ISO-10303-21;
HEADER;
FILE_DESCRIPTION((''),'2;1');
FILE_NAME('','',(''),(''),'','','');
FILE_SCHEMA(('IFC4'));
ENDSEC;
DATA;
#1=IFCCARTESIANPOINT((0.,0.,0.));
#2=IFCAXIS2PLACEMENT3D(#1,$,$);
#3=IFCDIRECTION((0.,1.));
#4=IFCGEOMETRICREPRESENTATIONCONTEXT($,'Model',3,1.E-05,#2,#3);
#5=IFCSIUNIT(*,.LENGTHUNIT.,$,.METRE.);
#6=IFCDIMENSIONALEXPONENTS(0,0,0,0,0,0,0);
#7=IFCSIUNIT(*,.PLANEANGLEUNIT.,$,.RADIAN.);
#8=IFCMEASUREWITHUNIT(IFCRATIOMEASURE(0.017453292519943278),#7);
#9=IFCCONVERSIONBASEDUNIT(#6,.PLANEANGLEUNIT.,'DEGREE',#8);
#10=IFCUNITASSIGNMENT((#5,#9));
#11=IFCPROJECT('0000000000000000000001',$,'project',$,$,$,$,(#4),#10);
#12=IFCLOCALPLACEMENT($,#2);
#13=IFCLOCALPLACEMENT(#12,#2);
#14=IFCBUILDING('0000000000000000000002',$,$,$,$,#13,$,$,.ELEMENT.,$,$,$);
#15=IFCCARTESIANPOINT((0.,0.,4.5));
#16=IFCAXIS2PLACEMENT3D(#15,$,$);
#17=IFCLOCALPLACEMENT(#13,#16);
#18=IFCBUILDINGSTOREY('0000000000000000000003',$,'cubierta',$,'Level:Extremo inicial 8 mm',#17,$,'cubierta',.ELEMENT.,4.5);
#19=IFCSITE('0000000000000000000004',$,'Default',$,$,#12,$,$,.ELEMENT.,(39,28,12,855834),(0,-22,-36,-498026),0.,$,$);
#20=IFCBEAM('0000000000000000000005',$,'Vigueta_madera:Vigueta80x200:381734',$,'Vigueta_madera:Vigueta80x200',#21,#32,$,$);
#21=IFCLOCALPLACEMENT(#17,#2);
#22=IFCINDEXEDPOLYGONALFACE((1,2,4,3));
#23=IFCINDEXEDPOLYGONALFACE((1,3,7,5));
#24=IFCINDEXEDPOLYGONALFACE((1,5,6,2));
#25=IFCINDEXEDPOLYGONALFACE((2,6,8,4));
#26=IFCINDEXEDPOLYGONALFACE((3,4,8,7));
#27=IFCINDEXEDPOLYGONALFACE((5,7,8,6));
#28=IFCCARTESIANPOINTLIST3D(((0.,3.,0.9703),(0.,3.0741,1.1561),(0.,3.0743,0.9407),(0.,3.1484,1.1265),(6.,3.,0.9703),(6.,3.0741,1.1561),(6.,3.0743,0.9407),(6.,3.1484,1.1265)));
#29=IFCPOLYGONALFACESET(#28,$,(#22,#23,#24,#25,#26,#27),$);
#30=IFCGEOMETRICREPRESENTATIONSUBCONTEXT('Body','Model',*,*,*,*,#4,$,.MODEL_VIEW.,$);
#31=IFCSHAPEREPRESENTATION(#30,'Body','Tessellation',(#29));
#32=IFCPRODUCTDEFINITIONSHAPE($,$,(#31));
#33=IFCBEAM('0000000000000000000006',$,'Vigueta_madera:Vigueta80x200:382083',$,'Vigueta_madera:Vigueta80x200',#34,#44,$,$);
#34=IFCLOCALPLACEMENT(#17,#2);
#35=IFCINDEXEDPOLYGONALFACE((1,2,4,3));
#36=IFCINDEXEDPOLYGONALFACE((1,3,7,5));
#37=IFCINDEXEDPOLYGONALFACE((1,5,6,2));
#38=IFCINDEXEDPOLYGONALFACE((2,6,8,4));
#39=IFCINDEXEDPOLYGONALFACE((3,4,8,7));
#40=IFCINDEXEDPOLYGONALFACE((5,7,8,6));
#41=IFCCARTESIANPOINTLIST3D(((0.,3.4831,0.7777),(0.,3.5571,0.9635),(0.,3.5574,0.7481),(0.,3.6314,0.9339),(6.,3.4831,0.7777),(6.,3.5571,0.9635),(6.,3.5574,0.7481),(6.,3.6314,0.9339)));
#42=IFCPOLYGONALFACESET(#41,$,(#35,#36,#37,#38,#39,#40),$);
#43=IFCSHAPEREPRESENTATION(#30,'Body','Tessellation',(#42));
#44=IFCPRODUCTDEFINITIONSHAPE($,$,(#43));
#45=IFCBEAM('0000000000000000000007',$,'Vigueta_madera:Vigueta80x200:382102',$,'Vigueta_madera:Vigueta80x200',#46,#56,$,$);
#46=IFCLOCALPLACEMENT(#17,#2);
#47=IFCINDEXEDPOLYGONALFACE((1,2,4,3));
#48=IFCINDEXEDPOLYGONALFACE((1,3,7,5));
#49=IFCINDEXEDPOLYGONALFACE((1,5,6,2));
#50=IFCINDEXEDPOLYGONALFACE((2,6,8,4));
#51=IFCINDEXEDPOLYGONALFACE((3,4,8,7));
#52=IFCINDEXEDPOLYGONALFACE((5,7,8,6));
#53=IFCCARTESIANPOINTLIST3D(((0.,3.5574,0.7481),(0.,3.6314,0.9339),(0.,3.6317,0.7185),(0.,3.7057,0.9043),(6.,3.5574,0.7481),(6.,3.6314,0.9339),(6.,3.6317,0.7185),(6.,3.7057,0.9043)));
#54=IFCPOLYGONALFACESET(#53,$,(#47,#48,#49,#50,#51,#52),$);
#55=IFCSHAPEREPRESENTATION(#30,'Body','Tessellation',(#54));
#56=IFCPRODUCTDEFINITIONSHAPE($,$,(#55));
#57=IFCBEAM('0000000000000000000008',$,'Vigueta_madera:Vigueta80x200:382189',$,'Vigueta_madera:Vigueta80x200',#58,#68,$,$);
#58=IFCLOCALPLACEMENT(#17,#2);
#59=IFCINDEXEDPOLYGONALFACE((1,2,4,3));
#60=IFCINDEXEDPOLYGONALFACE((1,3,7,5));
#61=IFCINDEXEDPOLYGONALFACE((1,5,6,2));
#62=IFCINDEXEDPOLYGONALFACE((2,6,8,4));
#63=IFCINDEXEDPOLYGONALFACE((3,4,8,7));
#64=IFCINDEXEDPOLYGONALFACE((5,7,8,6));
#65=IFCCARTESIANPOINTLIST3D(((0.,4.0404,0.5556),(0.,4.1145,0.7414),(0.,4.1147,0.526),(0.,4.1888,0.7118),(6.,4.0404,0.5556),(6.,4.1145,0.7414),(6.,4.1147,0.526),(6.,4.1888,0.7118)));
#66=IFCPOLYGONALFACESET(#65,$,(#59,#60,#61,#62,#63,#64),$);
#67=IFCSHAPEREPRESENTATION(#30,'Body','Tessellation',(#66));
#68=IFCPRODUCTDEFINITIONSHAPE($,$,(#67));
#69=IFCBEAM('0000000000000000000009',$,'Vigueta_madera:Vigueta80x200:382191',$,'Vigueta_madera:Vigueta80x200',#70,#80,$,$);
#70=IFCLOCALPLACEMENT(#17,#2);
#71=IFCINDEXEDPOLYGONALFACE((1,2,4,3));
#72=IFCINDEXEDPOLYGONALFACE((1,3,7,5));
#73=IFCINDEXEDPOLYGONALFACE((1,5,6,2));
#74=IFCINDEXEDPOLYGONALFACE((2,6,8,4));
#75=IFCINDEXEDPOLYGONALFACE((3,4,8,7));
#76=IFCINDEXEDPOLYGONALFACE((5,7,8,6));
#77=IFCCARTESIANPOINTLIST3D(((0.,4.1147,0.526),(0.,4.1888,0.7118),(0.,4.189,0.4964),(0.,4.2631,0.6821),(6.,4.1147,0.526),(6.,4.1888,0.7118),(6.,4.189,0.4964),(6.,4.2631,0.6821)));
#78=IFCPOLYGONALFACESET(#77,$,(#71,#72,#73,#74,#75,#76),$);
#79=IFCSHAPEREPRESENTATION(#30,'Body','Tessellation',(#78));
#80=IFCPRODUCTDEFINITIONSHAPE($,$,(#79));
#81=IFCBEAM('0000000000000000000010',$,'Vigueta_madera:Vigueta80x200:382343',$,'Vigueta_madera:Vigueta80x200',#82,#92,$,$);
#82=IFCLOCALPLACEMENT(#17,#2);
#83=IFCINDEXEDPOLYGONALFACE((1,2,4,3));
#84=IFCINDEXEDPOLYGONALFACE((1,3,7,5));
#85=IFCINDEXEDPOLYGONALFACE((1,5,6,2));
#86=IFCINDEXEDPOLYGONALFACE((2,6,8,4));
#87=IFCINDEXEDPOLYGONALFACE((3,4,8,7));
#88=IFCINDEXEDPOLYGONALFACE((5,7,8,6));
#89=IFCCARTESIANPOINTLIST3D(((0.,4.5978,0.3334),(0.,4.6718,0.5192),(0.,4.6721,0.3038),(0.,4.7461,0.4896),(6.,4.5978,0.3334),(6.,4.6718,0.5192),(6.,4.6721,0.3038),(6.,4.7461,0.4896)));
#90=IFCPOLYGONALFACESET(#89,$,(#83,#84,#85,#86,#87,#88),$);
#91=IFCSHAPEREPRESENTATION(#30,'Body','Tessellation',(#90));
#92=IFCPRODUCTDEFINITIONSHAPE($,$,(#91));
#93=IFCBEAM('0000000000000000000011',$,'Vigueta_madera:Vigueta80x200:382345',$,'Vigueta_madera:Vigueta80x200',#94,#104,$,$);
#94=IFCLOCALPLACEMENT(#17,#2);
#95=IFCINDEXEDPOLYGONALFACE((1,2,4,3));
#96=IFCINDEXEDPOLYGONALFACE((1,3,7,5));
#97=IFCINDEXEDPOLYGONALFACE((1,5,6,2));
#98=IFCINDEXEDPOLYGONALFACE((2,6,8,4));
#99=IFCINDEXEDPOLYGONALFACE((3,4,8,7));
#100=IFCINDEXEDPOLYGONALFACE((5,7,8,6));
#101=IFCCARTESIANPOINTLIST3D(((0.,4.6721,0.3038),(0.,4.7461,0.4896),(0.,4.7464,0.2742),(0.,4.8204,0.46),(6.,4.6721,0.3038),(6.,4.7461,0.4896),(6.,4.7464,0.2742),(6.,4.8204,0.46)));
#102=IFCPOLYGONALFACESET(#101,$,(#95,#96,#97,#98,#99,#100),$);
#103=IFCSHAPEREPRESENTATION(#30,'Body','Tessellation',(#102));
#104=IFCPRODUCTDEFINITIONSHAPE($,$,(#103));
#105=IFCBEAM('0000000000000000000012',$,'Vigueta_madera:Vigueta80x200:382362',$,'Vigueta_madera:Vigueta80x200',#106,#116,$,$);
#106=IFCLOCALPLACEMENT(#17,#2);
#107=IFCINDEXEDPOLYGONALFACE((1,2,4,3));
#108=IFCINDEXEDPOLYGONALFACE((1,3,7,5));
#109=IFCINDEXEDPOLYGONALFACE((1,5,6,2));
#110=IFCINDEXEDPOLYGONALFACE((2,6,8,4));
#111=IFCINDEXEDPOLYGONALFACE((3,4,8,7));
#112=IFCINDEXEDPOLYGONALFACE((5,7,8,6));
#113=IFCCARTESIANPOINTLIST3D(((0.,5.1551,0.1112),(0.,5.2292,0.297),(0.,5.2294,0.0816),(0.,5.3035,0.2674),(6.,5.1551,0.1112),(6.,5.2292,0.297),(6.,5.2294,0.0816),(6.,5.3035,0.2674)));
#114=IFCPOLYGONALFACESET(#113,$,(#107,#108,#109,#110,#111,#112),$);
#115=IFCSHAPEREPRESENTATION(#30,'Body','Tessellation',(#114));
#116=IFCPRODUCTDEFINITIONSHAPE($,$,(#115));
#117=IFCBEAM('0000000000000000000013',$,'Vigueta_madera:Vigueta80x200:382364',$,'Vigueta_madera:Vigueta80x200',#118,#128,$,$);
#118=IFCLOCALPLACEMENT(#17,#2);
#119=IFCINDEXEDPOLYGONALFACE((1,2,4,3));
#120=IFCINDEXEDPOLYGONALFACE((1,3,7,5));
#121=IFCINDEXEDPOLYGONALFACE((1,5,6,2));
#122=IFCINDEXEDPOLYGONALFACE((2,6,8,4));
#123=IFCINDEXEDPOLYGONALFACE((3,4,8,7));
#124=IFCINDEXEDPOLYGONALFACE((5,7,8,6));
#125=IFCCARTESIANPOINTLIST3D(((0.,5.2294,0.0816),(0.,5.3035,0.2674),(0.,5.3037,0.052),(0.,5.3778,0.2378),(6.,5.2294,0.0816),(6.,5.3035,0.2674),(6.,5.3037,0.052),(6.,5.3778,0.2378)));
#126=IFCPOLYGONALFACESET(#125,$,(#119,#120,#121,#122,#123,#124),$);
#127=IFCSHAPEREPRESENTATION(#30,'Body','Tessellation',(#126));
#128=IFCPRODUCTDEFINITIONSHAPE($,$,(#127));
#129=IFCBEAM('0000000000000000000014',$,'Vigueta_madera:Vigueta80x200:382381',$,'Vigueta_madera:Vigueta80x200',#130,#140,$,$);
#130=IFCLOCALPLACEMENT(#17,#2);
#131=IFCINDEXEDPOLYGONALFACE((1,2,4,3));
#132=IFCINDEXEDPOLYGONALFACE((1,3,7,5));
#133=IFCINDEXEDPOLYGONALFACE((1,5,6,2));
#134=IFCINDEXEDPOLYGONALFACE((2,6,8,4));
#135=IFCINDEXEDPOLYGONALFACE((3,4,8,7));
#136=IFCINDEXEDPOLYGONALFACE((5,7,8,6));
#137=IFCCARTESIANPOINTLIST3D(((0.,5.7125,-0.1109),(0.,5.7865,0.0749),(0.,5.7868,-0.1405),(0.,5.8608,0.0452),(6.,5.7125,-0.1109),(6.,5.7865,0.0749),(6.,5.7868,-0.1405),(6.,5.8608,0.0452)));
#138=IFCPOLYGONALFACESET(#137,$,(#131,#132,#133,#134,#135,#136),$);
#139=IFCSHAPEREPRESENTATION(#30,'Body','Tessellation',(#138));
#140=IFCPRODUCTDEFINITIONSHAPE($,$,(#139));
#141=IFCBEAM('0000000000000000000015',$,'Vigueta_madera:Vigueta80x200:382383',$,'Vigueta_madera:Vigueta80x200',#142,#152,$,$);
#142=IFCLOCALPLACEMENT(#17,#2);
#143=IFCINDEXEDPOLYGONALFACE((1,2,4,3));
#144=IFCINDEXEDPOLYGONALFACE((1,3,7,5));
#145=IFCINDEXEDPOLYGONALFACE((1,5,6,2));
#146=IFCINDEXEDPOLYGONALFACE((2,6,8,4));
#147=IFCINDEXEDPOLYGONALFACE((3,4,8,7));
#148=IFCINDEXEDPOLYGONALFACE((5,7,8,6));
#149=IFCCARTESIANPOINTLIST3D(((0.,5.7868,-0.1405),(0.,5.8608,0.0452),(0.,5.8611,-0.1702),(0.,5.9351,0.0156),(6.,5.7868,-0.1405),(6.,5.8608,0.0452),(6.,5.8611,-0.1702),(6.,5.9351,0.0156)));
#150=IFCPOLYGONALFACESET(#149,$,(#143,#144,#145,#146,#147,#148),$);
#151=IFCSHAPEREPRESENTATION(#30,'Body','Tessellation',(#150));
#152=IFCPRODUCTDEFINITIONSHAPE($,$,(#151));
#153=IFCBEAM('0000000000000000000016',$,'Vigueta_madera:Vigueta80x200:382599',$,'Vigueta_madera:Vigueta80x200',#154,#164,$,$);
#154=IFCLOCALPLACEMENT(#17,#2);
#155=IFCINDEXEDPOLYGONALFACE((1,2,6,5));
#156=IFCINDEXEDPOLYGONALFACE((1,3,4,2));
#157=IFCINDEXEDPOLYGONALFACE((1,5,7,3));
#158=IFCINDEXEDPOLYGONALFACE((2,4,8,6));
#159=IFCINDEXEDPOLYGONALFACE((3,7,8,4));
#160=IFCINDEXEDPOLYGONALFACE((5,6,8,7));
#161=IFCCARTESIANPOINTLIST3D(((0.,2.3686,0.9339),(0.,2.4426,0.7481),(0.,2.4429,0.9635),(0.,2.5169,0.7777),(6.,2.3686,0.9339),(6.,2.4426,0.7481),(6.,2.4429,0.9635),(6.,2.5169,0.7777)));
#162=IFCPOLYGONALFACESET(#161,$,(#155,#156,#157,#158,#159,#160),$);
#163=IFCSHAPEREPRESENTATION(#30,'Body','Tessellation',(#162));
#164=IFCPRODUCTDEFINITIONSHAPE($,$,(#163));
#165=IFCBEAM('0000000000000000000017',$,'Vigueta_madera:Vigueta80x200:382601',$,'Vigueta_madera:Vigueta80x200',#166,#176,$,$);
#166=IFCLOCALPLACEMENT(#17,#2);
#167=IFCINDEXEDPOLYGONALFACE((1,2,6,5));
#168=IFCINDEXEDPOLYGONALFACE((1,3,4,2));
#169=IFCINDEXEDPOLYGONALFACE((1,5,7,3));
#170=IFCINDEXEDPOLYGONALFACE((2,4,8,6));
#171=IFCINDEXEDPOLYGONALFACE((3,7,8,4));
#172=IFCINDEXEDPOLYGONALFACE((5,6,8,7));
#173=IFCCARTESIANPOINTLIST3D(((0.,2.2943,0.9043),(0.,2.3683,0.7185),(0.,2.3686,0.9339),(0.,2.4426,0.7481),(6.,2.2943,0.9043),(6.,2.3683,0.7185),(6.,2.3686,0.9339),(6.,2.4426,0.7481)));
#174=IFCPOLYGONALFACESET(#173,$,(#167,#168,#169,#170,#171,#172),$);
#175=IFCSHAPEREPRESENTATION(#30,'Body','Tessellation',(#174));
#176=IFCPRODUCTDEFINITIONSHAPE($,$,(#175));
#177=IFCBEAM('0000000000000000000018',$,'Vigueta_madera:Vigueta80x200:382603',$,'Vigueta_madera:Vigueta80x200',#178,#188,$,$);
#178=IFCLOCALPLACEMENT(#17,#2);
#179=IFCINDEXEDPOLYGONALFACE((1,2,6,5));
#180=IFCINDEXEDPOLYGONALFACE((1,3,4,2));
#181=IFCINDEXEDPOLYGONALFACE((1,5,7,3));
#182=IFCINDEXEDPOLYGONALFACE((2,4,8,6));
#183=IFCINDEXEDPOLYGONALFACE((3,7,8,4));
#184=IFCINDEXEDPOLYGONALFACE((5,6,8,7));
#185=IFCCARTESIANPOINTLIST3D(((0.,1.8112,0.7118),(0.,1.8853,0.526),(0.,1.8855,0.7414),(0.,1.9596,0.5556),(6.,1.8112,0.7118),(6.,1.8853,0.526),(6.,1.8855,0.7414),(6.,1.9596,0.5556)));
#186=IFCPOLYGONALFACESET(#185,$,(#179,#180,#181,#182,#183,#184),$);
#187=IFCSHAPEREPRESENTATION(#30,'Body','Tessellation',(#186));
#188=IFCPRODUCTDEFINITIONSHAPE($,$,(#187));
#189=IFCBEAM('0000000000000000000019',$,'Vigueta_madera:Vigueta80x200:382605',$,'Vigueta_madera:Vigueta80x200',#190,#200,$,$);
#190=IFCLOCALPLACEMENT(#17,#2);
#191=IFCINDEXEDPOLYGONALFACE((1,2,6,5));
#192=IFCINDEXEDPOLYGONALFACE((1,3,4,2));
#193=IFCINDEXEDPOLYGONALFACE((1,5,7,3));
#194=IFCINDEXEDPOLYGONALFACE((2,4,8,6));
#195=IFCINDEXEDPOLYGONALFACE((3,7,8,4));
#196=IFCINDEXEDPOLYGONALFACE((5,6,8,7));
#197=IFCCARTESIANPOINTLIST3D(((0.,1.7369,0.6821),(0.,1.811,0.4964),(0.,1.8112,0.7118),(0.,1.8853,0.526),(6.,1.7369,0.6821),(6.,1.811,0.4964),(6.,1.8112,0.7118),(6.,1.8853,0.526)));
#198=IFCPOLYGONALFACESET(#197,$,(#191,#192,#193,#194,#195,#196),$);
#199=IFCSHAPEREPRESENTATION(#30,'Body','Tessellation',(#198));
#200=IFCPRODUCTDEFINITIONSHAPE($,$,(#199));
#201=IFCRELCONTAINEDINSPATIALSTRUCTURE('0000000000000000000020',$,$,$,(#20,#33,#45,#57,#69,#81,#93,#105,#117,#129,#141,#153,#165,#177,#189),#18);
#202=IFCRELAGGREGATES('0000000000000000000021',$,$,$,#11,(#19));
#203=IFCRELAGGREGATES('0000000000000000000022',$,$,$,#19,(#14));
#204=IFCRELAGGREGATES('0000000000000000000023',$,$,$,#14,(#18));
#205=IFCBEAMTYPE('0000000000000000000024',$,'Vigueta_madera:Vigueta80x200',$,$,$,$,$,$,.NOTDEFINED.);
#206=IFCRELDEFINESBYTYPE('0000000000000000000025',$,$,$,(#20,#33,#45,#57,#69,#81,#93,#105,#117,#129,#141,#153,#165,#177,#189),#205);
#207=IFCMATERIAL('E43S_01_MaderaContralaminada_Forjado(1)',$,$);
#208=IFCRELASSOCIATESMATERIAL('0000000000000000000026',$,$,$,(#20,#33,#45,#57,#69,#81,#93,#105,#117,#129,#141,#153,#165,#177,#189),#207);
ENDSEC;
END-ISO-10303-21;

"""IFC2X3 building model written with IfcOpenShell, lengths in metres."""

from ifc_helpers import new_model, entity, si_unit, converted_unit, direction, frame, frame_2d, origin, place, context, subcontext, project, spatial, rectangle, extrude, material, type_object, element, save


model = new_model("IFC2X3")

# Units and contexts
model_context = context("Model", 3, precision=1e-05, world=origin(), true_north=direction((0.0, 1.0)))
body_context = subcontext(model_context, "Body", "Model", "MODEL_VIEW")
ifc_project = project(units=[si_unit("LENGTHUNIT", "METRE"), converted_unit("PLANEANGLEUNIT", "DEGREE", entity("IfcRatioMeasure", 0.017453292519943278), si_unit("PLANEANGLEUNIT", "RADIAN"), dimensions=[0, 0, 0, 0, 0, 0, 0])], contexts=[model_context])

# Site, building, storey
site_placement = place(None, origin())
site = spatial("IfcSite", under=ifc_project, at=site_placement, Name="Default", CompositionType="ELEMENT", RefLatitude=(39, 28, 12, 855834), RefLongitude=(0, -22, -36, -498026), RefElevation=0.0)
building_placement = place(site_placement, origin())
building = spatial("IfcBuilding", under=site, at=building_placement, CompositionType="ELEMENT")
storey_placement = place(building_placement, frame((0.0, 0.0, 4.5)))
storey = spatial("IfcBuildingStorey", under=building, at=storey_placement, Name="cubierta", ObjectType="Level:Extremo inicial 8 mm", LongName="cubierta", CompositionType="ELEMENT", Elevation=4.5)

# Beams
ifc_material_1 = material(Name="E43S_01_MaderaContralaminada_Forjado(1)")
beam_type = type_object("IfcBeamType", Name="Vigueta_madera:Vigueta80x200", PredefinedType="NOTDEFINED")
beam_1_placement = place(storey_placement, frame((0.0, 3.1112, 1.1413)))
element("IfcBeam", 1, at=beam_1_placement, inside=storey, type_object=beam_type, material=ifc_material_1, Name="Vigueta_madera:Vigueta80x200:381734", ObjectType="Vigueta_madera:Vigueta80x200", context=body_context, shape_type="SweptSolid", body=[
    extrude(rectangle(XDim=0.2, YDim=0.08, at=frame_2d((0.0, 0.0), x_axis=(0.0, 1.0))), frame((0.0, -0.037, -0.0929), z_axis=(1.0, 0.0, 0.0), x_axis=(0.0, -0.928939, 0.370233)), (0.0, 0.0, 1.0), 6.0),
])
beam_2_placement = place(storey_placement, frame((0.0, 3.5943, 0.9487)))
element("IfcBeam", 2, at=beam_2_placement, inside=storey, type_object=beam_type, material=ifc_material_1, Name="Vigueta_madera:Vigueta80x200:382083", ObjectType="Vigueta_madera:Vigueta80x200", context=body_context, shape_type="SweptSolid", body=[
    extrude(rectangle(XDim=0.2, YDim=0.08, at=frame_2d((0.0, 0.0), x_axis=(0.0, 1.0))), frame((0.0, -0.037, -0.0929), z_axis=(1.0, 0.0, 0.0), x_axis=(0.0, -0.928939, 0.370233)), (0.0, 0.0, 1.0), 6.0),
])
for number, where, name in (
    (3, (0.0, 3.6686, 0.9191), "Vigueta_madera:Vigueta80x200:382102"),
    (4, (0.0, 4.1516, 0.7266), "Vigueta_madera:Vigueta80x200:382189"),
):
    element("IfcBeam", number, at=place(storey_placement, frame(where)), inside=storey, type_object=beam_type, material=ifc_material_1, Name=name, ObjectType="Vigueta_madera:Vigueta80x200", context=body_context, shape_type="SweptSolid", body=[
        extrude(rectangle(XDim=0.2, YDim=0.08, at=frame_2d((0.0, 0.0), x_axis=(0.0, 1.0))), frame((0.0, -0.037, -0.0929), z_axis=(1.0, 0.0, 0.0), x_axis=(0.0, -0.928939, 0.370233)), (0.0, 0.0, 1.0), 6.0),
    ])
beam_3_placement = place(storey_placement, frame((0.0, 4.2259, 0.697)))
element("IfcBeam", 5, at=beam_3_placement, inside=storey, type_object=beam_type, material=ifc_material_1, Name="Vigueta_madera:Vigueta80x200:382191", ObjectType="Vigueta_madera:Vigueta80x200", context=body_context, shape_type="SweptSolid", body=[
    extrude(rectangle(XDim=0.2, YDim=0.08, at=frame_2d((0.0, 0.0), x_axis=(0.0, 1.0))), frame((0.0, -0.037, -0.0929), z_axis=(1.0, 0.0, 0.0), x_axis=(0.0, -0.928939, 0.370233)), (0.0, 0.0, 1.0), 6.0),
])
for number, where, name in (
    (6, (0.0, 4.709, 0.5044), "Vigueta_madera:Vigueta80x200:382343"),
    (7, (0.0, 4.7833, 0.4748), "Vigueta_madera:Vigueta80x200:382345"),
):
    element("IfcBeam", number, at=place(storey_placement, frame(where)), inside=storey, type_object=beam_type, material=ifc_material_1, Name=name, ObjectType="Vigueta_madera:Vigueta80x200", context=body_context, shape_type="SweptSolid", body=[
        extrude(rectangle(XDim=0.2, YDim=0.08, at=frame_2d((0.0, 0.0), x_axis=(0.0, 1.0))), frame((0.0, -0.037, -0.0929), z_axis=(1.0, 0.0, 0.0), x_axis=(0.0, -0.928939, 0.370233)), (0.0, 0.0, 1.0), 6.0),
    ])
beam_4_placement = place(storey_placement, frame((0.0, 5.2663, 0.2822)))
element("IfcBeam", 8, at=beam_4_placement, inside=storey, type_object=beam_type, material=ifc_material_1, Name="Vigueta_madera:Vigueta80x200:382362", ObjectType="Vigueta_madera:Vigueta80x200", context=body_context, shape_type="SweptSolid", body=[
    extrude(rectangle(XDim=0.2, YDim=0.08, at=frame_2d((0.0, 0.0), x_axis=(0.0, 1.0))), frame((0.0, -0.037, -0.0929), z_axis=(1.0, 0.0, 0.0), x_axis=(0.0, -0.928939, 0.370233)), (0.0, 0.0, 1.0), 6.0),
])
for number, where, name in (
    (9, (0.0, 5.3406, 0.2526), "Vigueta_madera:Vigueta80x200:382364"),
    (10, (0.0, 5.8237, 0.0601), "Vigueta_madera:Vigueta80x200:382381"),
):
    element("IfcBeam", number, at=place(storey_placement, frame(where)), inside=storey, type_object=beam_type, material=ifc_material_1, Name=name, ObjectType="Vigueta_madera:Vigueta80x200", context=body_context, shape_type="SweptSolid", body=[
        extrude(rectangle(XDim=0.2, YDim=0.08, at=frame_2d((0.0, 0.0), x_axis=(0.0, 1.0))), frame((0.0, -0.037, -0.0929), z_axis=(1.0, 0.0, 0.0), x_axis=(0.0, -0.928939, 0.370233)), (0.0, 0.0, 1.0), 6.0),
    ])
beam_5_placement = place(storey_placement, frame((0.0, 5.898, 0.0304)))
element("IfcBeam", 11, at=beam_5_placement, inside=storey, type_object=beam_type, material=ifc_material_1, Name="Vigueta_madera:Vigueta80x200:382383", ObjectType="Vigueta_madera:Vigueta80x200", context=body_context, shape_type="SweptSolid", body=[
    extrude(rectangle(XDim=0.2, YDim=0.08, at=frame_2d((0.0, 0.0), x_axis=(0.0, 1.0))), frame((0.0, -0.037, -0.0929), z_axis=(1.0, 0.0, 0.0), x_axis=(0.0, -0.928939, 0.370233)), (0.0, 0.0, 1.0), 6.0),
])
beam_6_placement = place(storey_placement, frame((0.0, 2.4057, 0.9487)))
element("IfcBeam", 12, at=beam_6_placement, inside=storey, type_object=beam_type, material=ifc_material_1, Name="Vigueta_madera:Vigueta80x200:382599", ObjectType="Vigueta_madera:Vigueta80x200", context=body_context, shape_type="SweptSolid", body=[
    extrude(rectangle(XDim=0.2, YDim=0.08, at=frame_2d((0.0, 0.0), x_axis=(1.0, 0.0))), frame((0.0, 0.037, -0.0929), z_axis=(1.0, 0.0, 0.0), x_axis=(0.0, -0.370233, 0.928939)), (0.0, 0.0, 1.0), 6.0),
])
beam_7_placement = place(storey_placement, frame((0.0, 2.3314, 0.9191)))
element("IfcBeam", 13, at=beam_7_placement, inside=storey, type_object=beam_type, material=ifc_material_1, Name="Vigueta_madera:Vigueta80x200:382601", ObjectType="Vigueta_madera:Vigueta80x200", context=body_context, shape_type="SweptSolid", body=[
    extrude(rectangle(XDim=0.2, YDim=0.08, at=frame_2d((0.0, 0.0), x_axis=(1.0, 0.0))), frame((0.0, 0.037, -0.0929), z_axis=(1.0, 0.0, 0.0), x_axis=(0.0, -0.370233, 0.928939)), (0.0, 0.0, 1.0), 6.0),
])
beam_8_placement = place(storey_placement, frame((0.0, 1.8484, 0.7266)))
element("IfcBeam", 14, at=beam_8_placement, inside=storey, type_object=beam_type, material=ifc_material_1, Name="Vigueta_madera:Vigueta80x200:382603", ObjectType="Vigueta_madera:Vigueta80x200", context=body_context, shape_type="SweptSolid", body=[
    extrude(rectangle(XDim=0.2, YDim=0.08, at=frame_2d((0.0, 0.0), x_axis=(1.0, 0.0))), frame((0.0, 0.037, -0.0929), z_axis=(1.0, 0.0, 0.0), x_axis=(0.0, -0.370233, 0.928939)), (0.0, 0.0, 1.0), 6.0),
])
beam_9_placement = place(storey_placement, frame((0.0, 1.7741, 0.697)))
element("IfcBeam", 15, at=beam_9_placement, inside=storey, type_object=beam_type, material=ifc_material_1, Name="Vigueta_madera:Vigueta80x200:382605", ObjectType="Vigueta_madera:Vigueta80x200", context=body_context, shape_type="SweptSolid", body=[
    extrude(rectangle(XDim=0.2, YDim=0.08, at=frame_2d((0.0, 0.0), x_axis=(1.0, 0.0))), frame((0.0, 0.037, -0.0929), z_axis=(1.0, 0.0, 0.0), x_axis=(0.0, -0.370233, 0.928939)), (0.0, 0.0, 1.0), 6.0),
])

save(model, "model.ifc")
